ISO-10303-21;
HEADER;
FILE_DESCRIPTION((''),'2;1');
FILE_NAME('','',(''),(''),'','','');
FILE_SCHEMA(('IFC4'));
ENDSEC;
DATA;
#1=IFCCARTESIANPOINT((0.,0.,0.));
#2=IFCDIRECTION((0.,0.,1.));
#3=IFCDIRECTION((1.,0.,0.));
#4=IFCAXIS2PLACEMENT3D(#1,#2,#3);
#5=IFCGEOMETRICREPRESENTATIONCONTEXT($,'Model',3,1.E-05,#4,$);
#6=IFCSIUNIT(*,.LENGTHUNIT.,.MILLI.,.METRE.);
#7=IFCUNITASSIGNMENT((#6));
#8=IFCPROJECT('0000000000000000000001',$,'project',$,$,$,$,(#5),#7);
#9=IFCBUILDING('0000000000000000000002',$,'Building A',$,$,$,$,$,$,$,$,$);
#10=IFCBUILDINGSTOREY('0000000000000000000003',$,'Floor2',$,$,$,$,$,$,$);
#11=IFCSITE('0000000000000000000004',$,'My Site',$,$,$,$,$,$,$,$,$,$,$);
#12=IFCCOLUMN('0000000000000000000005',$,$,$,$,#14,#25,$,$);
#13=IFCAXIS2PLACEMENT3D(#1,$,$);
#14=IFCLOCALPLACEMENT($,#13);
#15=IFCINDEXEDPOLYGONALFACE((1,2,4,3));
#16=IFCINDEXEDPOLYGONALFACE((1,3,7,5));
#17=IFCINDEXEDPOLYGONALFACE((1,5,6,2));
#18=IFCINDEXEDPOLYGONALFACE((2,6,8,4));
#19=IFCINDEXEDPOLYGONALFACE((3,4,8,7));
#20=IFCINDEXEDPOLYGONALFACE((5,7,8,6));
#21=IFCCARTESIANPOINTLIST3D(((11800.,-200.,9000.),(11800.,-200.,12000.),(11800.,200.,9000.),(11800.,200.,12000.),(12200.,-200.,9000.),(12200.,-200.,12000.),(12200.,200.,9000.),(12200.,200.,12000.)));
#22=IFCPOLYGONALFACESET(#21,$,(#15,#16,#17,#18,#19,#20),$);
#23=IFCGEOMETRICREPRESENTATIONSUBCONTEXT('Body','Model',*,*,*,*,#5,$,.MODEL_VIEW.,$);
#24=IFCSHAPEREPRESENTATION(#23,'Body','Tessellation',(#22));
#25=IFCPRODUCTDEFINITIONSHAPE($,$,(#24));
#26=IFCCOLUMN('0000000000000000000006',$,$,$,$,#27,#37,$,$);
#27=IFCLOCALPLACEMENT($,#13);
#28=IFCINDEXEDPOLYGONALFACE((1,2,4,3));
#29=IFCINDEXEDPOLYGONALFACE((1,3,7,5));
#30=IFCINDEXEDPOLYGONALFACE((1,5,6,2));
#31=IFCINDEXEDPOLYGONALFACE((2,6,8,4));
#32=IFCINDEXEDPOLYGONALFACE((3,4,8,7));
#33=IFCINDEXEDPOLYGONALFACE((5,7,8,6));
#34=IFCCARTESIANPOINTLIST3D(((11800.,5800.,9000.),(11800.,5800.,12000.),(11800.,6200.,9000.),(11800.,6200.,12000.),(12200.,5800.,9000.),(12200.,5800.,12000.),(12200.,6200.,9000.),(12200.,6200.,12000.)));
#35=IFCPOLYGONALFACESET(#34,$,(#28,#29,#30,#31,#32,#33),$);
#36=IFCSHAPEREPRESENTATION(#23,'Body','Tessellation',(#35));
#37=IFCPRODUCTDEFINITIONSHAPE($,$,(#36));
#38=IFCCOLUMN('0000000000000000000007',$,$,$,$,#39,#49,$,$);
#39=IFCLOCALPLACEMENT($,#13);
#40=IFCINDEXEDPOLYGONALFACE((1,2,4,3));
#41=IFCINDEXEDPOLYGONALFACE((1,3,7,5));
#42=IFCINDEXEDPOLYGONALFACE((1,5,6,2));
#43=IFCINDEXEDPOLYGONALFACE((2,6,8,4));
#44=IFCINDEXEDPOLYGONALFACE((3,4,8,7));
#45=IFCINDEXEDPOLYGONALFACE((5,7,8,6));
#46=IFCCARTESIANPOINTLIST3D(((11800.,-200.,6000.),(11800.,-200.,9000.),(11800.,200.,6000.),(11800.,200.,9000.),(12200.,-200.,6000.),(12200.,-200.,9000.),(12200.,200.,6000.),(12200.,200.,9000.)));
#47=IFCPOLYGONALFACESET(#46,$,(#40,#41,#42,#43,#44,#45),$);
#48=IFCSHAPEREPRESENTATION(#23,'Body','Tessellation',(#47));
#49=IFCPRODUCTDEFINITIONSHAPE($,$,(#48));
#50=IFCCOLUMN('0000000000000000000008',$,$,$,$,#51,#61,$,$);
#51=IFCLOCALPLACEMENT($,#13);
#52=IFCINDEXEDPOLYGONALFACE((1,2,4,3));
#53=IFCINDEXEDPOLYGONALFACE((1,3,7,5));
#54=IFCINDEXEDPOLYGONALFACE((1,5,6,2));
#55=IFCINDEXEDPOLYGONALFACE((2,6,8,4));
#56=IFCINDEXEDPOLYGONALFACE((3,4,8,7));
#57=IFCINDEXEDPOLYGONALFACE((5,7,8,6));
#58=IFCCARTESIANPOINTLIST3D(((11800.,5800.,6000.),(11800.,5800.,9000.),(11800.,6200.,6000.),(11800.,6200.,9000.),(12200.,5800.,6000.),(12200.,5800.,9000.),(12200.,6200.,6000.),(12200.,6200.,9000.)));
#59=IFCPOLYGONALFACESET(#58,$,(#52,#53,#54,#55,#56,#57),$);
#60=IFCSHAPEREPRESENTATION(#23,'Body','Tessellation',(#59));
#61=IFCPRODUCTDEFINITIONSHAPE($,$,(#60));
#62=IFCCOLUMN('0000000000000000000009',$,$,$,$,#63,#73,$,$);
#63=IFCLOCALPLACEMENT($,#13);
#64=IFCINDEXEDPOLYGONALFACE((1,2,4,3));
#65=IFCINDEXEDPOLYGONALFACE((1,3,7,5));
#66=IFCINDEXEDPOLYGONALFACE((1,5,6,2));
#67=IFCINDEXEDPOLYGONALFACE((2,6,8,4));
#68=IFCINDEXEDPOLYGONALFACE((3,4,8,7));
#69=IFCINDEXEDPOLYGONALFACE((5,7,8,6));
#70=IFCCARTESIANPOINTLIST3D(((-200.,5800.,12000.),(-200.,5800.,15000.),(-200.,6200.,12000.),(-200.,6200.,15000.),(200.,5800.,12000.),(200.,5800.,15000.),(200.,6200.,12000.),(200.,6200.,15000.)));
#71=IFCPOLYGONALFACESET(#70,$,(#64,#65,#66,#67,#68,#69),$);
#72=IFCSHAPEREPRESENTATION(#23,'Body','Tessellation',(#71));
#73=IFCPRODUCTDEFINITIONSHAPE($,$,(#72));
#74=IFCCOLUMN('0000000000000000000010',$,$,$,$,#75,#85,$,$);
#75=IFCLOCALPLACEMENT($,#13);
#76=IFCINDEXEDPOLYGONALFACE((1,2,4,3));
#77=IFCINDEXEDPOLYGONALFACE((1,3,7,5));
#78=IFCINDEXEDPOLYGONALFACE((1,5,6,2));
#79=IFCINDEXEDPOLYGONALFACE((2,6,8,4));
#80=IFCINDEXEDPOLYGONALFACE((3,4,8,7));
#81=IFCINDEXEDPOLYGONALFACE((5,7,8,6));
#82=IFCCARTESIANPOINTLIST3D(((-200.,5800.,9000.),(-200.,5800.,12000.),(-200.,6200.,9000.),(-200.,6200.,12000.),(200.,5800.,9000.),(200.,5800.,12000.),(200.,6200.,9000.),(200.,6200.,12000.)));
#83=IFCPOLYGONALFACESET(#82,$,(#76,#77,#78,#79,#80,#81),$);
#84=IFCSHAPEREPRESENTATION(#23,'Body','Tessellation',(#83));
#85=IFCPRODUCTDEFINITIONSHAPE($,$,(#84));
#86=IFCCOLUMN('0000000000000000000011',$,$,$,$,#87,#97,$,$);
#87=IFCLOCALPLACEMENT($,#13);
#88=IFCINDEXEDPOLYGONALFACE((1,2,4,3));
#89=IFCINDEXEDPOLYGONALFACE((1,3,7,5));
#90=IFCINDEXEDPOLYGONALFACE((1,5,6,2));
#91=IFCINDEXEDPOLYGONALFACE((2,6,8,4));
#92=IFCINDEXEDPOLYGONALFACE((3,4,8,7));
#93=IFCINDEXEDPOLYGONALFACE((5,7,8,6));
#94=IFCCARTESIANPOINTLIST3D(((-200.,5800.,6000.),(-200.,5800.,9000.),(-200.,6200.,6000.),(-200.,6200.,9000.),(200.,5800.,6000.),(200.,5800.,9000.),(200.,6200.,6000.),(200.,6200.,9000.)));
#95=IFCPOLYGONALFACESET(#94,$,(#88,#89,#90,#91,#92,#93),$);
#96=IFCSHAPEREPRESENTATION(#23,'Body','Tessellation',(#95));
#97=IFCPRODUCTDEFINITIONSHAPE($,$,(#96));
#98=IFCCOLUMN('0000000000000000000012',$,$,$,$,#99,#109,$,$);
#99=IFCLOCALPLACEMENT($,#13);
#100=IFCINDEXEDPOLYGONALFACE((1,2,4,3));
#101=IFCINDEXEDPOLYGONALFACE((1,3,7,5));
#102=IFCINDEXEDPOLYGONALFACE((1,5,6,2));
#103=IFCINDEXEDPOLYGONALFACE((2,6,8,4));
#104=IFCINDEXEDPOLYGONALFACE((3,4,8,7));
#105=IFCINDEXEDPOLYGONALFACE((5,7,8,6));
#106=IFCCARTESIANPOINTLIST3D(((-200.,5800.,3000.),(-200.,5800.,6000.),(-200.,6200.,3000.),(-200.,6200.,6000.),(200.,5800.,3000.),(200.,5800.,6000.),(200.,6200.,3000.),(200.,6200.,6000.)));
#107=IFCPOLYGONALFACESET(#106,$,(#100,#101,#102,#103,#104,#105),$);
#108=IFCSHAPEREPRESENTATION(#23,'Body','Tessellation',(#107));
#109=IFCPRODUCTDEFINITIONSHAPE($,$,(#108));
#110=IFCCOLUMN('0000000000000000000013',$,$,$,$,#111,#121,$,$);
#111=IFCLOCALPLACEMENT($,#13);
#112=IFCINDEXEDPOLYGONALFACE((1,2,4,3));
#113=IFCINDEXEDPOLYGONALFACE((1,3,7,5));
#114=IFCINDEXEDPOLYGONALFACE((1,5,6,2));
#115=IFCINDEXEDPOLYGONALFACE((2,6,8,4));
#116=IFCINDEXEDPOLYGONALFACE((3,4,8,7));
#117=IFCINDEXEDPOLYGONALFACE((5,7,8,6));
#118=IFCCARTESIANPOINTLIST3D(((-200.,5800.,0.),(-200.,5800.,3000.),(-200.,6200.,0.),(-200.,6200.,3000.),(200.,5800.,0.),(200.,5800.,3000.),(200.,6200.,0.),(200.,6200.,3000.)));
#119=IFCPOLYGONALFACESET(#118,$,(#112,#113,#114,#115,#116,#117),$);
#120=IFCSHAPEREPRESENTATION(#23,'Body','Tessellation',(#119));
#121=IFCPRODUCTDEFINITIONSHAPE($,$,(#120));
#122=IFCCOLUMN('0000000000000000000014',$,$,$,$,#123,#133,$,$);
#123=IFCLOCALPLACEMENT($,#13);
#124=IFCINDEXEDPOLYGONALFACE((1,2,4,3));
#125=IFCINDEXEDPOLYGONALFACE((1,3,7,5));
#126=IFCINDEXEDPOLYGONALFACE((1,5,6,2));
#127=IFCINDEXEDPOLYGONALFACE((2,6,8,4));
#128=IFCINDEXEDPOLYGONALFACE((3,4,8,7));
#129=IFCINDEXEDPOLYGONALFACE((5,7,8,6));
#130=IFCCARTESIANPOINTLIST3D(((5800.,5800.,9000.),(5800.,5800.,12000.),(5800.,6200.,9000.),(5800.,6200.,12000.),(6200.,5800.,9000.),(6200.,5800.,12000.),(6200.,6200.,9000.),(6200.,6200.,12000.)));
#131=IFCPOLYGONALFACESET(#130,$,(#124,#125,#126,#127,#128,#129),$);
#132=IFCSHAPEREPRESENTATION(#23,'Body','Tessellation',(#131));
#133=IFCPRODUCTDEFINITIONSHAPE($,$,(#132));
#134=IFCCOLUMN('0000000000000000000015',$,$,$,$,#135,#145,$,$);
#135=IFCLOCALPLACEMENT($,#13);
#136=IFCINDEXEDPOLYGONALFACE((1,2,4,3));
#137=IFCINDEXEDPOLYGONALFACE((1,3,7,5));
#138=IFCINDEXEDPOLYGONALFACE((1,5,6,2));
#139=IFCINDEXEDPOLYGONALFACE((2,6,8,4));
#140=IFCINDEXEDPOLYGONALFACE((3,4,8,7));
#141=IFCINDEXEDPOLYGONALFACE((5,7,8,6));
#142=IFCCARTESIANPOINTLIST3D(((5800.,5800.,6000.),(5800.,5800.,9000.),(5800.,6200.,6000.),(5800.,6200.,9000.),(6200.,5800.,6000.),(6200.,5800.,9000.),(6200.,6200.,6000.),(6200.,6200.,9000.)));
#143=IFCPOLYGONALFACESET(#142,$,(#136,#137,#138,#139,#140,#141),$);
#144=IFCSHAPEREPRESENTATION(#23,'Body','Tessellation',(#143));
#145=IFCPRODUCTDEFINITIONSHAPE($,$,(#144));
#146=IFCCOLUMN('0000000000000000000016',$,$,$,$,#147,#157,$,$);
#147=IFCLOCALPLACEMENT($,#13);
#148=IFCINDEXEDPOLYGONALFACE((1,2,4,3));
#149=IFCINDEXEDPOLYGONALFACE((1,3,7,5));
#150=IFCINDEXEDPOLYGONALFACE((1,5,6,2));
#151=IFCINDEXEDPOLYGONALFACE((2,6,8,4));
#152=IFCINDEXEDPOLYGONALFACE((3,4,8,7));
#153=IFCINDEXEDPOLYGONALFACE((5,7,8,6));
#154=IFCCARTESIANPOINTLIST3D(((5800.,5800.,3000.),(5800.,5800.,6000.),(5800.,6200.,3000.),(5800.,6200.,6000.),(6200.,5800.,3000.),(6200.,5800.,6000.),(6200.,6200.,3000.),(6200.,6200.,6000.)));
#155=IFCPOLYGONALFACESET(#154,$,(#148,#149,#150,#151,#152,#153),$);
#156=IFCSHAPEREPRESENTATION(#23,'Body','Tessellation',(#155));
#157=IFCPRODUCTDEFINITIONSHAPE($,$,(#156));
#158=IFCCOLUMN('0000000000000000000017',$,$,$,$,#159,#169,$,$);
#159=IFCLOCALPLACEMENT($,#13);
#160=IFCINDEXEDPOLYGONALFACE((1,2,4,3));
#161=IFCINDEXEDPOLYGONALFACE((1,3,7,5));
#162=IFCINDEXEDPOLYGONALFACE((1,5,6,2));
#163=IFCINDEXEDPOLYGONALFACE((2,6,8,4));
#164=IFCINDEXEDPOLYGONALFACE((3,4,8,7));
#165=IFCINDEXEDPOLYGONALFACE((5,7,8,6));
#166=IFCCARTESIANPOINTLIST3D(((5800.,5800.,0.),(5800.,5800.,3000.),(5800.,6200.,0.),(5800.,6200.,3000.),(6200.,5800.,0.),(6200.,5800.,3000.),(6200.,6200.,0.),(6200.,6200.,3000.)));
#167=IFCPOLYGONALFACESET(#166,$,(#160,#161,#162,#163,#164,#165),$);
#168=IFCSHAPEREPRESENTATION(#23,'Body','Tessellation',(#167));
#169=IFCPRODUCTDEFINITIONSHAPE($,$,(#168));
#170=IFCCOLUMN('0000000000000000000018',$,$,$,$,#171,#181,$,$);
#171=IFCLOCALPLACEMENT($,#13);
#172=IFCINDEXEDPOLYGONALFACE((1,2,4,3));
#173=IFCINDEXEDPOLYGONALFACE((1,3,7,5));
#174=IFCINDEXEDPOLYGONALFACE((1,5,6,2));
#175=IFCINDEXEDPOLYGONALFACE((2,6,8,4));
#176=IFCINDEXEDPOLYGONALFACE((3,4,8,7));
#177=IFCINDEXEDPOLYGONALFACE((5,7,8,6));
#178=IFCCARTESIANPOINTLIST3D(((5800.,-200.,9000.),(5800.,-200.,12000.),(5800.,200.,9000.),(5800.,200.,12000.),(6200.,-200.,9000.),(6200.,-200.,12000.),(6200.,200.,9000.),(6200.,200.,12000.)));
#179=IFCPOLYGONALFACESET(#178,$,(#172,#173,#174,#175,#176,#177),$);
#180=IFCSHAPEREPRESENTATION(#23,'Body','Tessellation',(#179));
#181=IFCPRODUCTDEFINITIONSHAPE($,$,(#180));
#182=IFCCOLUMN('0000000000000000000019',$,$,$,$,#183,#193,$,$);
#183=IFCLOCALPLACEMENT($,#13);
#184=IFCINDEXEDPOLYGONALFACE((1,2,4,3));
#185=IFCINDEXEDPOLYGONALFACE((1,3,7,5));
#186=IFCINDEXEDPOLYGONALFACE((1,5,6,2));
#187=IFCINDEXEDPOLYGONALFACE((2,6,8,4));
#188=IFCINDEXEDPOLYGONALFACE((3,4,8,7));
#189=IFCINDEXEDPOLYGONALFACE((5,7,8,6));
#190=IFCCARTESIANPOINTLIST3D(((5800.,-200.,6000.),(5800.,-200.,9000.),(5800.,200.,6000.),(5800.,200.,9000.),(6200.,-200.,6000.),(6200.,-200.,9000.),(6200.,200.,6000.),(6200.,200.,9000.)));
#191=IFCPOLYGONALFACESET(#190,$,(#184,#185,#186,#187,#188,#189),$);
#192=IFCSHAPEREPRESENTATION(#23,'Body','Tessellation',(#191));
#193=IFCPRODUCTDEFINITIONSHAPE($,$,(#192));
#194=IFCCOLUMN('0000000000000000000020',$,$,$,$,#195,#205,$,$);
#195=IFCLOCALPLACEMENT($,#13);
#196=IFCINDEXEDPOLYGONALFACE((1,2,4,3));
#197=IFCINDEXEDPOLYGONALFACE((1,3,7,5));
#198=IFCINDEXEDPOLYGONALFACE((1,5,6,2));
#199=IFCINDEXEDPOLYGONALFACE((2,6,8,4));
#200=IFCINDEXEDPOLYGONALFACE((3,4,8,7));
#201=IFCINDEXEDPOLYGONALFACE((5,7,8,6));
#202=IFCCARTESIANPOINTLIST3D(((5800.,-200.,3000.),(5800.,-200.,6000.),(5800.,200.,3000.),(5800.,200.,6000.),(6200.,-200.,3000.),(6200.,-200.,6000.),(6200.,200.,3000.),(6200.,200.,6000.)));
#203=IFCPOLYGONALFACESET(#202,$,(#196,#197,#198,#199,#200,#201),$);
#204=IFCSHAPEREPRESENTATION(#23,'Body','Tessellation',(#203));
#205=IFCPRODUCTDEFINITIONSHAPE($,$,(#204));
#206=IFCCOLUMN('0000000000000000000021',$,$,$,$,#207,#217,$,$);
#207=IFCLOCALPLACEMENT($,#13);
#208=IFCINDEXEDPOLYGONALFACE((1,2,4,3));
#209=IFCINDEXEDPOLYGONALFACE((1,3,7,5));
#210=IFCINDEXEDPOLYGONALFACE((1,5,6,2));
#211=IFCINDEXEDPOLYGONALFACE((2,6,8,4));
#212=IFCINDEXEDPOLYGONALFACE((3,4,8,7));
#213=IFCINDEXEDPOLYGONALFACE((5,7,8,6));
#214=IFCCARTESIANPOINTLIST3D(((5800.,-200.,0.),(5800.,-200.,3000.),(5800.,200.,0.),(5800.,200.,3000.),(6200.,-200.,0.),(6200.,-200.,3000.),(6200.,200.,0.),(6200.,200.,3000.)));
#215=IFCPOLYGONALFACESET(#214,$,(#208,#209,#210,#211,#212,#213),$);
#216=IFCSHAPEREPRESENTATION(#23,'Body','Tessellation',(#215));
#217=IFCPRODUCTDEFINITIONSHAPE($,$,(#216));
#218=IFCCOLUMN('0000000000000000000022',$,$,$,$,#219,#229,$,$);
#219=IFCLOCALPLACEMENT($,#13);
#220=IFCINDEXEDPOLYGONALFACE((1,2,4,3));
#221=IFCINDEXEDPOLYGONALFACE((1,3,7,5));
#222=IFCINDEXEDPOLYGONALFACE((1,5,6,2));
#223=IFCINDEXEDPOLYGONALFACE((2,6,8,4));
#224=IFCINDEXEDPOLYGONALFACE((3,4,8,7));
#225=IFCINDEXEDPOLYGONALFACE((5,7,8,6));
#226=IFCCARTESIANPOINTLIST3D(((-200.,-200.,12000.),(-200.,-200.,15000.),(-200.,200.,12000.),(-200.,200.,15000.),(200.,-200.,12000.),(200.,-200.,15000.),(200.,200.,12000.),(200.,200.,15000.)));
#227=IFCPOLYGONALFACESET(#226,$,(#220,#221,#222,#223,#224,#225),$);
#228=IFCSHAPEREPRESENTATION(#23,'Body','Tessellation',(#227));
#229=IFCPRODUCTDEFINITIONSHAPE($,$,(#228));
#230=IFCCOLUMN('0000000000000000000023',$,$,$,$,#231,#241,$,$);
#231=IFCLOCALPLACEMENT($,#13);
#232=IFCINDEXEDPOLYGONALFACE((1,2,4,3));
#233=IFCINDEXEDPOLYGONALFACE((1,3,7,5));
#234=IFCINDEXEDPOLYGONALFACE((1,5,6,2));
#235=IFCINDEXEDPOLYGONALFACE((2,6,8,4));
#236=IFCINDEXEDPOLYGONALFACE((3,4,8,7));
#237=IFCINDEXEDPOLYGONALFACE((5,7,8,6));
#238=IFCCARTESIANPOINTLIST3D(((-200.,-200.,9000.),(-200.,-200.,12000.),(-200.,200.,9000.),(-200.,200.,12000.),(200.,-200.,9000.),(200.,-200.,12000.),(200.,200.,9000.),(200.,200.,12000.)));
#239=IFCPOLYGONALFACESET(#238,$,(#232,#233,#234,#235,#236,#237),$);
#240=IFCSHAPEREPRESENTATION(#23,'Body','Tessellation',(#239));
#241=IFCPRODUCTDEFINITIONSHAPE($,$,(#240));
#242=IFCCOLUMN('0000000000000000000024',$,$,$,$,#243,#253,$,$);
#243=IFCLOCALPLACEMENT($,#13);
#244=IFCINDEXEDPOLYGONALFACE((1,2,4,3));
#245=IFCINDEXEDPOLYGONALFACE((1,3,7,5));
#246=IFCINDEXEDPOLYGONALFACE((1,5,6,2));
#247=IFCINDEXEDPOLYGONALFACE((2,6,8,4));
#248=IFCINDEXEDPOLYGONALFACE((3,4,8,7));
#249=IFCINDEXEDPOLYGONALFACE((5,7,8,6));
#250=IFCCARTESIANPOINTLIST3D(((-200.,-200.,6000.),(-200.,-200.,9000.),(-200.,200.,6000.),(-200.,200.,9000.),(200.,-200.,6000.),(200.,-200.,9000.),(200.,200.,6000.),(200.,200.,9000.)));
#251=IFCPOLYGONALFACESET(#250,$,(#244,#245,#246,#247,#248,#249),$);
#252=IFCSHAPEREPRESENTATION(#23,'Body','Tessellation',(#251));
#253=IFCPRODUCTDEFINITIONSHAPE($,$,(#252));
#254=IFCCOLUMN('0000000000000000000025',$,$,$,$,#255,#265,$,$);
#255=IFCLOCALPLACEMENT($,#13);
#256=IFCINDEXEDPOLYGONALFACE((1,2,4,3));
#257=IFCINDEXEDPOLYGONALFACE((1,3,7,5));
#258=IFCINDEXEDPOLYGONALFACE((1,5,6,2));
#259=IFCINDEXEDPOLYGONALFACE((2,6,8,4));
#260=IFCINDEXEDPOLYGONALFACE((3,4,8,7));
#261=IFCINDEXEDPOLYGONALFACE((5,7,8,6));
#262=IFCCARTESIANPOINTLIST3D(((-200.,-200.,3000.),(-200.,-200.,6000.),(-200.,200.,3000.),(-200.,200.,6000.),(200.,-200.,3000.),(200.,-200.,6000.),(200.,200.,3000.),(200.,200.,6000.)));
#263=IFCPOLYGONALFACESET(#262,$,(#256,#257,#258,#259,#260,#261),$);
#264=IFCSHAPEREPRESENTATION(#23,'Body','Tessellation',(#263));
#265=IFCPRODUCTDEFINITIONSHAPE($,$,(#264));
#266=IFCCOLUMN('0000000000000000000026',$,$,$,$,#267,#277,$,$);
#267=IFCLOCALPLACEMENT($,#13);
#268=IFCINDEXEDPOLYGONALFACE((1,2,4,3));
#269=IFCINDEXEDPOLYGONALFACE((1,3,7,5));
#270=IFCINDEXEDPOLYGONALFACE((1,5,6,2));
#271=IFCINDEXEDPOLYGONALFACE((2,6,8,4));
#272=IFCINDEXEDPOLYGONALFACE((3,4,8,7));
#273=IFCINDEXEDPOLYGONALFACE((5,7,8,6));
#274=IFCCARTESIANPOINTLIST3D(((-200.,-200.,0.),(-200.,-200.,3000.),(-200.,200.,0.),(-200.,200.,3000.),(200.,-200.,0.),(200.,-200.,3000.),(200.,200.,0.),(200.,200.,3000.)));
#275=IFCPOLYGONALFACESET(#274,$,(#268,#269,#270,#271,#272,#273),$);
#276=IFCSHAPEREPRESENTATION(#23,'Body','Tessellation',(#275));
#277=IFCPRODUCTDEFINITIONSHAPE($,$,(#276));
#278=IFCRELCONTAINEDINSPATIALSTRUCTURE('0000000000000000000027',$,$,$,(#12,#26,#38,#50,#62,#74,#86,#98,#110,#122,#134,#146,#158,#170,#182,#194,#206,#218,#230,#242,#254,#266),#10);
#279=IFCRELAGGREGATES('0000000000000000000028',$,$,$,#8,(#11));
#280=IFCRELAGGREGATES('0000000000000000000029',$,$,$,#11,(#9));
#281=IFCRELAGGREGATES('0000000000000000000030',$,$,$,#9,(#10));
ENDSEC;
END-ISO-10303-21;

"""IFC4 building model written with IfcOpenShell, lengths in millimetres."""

from ifc_helpers import new_model, si_unit, frame, origin_with_axes, place, context, subcontext, project, spatial, line, indexed_curve, outline, extrude, element, save


model = new_model("IFC4")

# Units and contexts
model_context = context("Model", 3, precision=1e-05, world=origin_with_axes())
body_context = subcontext(model_context, "Body", "Model", "MODEL_VIEW")
ifc_project = project(units=[si_unit("LENGTHUNIT", "METRE", prefix="MILLI")], contexts=[model_context])

# Site, building, storey
site = spatial("IfcSite", under=ifc_project, Name="My Site")
building = spatial("IfcBuilding", under=site, Name="Building A")
storey = spatial("IfcBuildingStorey", under=building, Name="Floor2")

# Columns
for number, where, z_axis, x_axis in (
    (1, (12000.0, 0.0, 9000.0), (0.0, 0.0, 1.0), (1.0, 0.0, 0.0)),
    (2, (12000.0, 6000.0, 9000.0), (0.0, 0.0, 1.0), (1.0, 0.0, 0.0)),
    (3, (12000.0, 0.0, 6000.0), (0.0, 0.0, 1.0), (1.0, 0.0, 0.0)),
    (4, (12000.0, 6000.0, 6000.0), (0.0, 0.0, 1.0), (1.0, 0.0, 0.0)),
    (5, (0.0, 6000.0, 12000.0), (0.0, 0.0, 1.0), (1.0, 0.0, 0.0)),
    (6, (0.0, 6000.0, 9000.0), (0.0, 0.0, 1.0), (1.0, 0.0, 0.0)),
    (7, (0.0, 6000.0, 6000.0), (0.0, 0.0, 1.0), (1.0, 0.0, 0.0)),
    (8, (0.0, 6000.0, 3000.0), (0.0, 0.0, 1.0), (1.0, 0.0, 0.0)),
    (9, (0.0, 6000.0, 0.0), (0.0, 0.0, 1.0), (1.0, 0.0, 0.0)),
    (10, (6000.0, 6000.0, 9000.0), (0.0, 0.0, 1.0), (1.0, 0.0, 0.0)),
    (11, (6000.0, 6000.0, 6000.0), (0.0, 0.0, 1.0), (1.0, 0.0, 0.0)),
    (12, (6000.0, 6000.0, 3000.0), (0.0, 0.0, 1.0), (1.0, 0.0, 0.0)),
    (13, (6000.0, 6000.0, 0.0), (0.0, 0.0, 1.0), (1.0, 0.0, 0.0)),
    (14, (6000.0, 0.0, 9000.0), (0.0, 0.0, 1.0), (1.0, 0.0, 0.0)),
    (15, (6000.0, 0.0, 6000.0), (0.0, 0.0, 1.0), (1.0, 0.0, 0.0)),
    (16, (6000.0, 0.0, 3000.0), (0.0, 0.0, 1.0), (1.0, 0.0, 0.0)),
    (17, (6000.0, 0.0, 0.0), (0.0, 0.0, 1.0), (1.0, 0.0, 0.0)),
    (18, (0.0, 0.0, 12000.0), (0.0, 0.0, 1.0), (1.0, 0.0, 0.0)),
    (19, (0.0, 0.0, 9000.0), (0.0, 0.0, 1.0), (1.0, 0.0, 0.0)),
    (20, (0.0, 0.0, 6000.0), (0.0, 0.0, 1.0), (1.0, 0.0, 0.0)),
    (21, (0.0, 0.0, 3000.0), (0.0, 0.0, 1.0), (1.0, 0.0, 0.0)),
    (22, (0.0, 0.0, 0.0), (0.0, 0.0, 1.0), (1.0, 0.0, 0.0)),
):
    element("IfcColumn", number, at=place(None, frame(where, z_axis=z_axis, x_axis=x_axis)), inside=storey, context=body_context, shape_type="SweptSolid", body=[
        extrude(outline(indexed_curve([(-200.0, -200.0), (200.0, -200.0), (200.0, 200.0), (-200.0, 200.0)], segments=[line(1, 2, 3, 4, 1)])), origin_with_axes(), (0.0, 0.0, 1.0), 3000.0),
    ])

save(model, "model.ifc")
